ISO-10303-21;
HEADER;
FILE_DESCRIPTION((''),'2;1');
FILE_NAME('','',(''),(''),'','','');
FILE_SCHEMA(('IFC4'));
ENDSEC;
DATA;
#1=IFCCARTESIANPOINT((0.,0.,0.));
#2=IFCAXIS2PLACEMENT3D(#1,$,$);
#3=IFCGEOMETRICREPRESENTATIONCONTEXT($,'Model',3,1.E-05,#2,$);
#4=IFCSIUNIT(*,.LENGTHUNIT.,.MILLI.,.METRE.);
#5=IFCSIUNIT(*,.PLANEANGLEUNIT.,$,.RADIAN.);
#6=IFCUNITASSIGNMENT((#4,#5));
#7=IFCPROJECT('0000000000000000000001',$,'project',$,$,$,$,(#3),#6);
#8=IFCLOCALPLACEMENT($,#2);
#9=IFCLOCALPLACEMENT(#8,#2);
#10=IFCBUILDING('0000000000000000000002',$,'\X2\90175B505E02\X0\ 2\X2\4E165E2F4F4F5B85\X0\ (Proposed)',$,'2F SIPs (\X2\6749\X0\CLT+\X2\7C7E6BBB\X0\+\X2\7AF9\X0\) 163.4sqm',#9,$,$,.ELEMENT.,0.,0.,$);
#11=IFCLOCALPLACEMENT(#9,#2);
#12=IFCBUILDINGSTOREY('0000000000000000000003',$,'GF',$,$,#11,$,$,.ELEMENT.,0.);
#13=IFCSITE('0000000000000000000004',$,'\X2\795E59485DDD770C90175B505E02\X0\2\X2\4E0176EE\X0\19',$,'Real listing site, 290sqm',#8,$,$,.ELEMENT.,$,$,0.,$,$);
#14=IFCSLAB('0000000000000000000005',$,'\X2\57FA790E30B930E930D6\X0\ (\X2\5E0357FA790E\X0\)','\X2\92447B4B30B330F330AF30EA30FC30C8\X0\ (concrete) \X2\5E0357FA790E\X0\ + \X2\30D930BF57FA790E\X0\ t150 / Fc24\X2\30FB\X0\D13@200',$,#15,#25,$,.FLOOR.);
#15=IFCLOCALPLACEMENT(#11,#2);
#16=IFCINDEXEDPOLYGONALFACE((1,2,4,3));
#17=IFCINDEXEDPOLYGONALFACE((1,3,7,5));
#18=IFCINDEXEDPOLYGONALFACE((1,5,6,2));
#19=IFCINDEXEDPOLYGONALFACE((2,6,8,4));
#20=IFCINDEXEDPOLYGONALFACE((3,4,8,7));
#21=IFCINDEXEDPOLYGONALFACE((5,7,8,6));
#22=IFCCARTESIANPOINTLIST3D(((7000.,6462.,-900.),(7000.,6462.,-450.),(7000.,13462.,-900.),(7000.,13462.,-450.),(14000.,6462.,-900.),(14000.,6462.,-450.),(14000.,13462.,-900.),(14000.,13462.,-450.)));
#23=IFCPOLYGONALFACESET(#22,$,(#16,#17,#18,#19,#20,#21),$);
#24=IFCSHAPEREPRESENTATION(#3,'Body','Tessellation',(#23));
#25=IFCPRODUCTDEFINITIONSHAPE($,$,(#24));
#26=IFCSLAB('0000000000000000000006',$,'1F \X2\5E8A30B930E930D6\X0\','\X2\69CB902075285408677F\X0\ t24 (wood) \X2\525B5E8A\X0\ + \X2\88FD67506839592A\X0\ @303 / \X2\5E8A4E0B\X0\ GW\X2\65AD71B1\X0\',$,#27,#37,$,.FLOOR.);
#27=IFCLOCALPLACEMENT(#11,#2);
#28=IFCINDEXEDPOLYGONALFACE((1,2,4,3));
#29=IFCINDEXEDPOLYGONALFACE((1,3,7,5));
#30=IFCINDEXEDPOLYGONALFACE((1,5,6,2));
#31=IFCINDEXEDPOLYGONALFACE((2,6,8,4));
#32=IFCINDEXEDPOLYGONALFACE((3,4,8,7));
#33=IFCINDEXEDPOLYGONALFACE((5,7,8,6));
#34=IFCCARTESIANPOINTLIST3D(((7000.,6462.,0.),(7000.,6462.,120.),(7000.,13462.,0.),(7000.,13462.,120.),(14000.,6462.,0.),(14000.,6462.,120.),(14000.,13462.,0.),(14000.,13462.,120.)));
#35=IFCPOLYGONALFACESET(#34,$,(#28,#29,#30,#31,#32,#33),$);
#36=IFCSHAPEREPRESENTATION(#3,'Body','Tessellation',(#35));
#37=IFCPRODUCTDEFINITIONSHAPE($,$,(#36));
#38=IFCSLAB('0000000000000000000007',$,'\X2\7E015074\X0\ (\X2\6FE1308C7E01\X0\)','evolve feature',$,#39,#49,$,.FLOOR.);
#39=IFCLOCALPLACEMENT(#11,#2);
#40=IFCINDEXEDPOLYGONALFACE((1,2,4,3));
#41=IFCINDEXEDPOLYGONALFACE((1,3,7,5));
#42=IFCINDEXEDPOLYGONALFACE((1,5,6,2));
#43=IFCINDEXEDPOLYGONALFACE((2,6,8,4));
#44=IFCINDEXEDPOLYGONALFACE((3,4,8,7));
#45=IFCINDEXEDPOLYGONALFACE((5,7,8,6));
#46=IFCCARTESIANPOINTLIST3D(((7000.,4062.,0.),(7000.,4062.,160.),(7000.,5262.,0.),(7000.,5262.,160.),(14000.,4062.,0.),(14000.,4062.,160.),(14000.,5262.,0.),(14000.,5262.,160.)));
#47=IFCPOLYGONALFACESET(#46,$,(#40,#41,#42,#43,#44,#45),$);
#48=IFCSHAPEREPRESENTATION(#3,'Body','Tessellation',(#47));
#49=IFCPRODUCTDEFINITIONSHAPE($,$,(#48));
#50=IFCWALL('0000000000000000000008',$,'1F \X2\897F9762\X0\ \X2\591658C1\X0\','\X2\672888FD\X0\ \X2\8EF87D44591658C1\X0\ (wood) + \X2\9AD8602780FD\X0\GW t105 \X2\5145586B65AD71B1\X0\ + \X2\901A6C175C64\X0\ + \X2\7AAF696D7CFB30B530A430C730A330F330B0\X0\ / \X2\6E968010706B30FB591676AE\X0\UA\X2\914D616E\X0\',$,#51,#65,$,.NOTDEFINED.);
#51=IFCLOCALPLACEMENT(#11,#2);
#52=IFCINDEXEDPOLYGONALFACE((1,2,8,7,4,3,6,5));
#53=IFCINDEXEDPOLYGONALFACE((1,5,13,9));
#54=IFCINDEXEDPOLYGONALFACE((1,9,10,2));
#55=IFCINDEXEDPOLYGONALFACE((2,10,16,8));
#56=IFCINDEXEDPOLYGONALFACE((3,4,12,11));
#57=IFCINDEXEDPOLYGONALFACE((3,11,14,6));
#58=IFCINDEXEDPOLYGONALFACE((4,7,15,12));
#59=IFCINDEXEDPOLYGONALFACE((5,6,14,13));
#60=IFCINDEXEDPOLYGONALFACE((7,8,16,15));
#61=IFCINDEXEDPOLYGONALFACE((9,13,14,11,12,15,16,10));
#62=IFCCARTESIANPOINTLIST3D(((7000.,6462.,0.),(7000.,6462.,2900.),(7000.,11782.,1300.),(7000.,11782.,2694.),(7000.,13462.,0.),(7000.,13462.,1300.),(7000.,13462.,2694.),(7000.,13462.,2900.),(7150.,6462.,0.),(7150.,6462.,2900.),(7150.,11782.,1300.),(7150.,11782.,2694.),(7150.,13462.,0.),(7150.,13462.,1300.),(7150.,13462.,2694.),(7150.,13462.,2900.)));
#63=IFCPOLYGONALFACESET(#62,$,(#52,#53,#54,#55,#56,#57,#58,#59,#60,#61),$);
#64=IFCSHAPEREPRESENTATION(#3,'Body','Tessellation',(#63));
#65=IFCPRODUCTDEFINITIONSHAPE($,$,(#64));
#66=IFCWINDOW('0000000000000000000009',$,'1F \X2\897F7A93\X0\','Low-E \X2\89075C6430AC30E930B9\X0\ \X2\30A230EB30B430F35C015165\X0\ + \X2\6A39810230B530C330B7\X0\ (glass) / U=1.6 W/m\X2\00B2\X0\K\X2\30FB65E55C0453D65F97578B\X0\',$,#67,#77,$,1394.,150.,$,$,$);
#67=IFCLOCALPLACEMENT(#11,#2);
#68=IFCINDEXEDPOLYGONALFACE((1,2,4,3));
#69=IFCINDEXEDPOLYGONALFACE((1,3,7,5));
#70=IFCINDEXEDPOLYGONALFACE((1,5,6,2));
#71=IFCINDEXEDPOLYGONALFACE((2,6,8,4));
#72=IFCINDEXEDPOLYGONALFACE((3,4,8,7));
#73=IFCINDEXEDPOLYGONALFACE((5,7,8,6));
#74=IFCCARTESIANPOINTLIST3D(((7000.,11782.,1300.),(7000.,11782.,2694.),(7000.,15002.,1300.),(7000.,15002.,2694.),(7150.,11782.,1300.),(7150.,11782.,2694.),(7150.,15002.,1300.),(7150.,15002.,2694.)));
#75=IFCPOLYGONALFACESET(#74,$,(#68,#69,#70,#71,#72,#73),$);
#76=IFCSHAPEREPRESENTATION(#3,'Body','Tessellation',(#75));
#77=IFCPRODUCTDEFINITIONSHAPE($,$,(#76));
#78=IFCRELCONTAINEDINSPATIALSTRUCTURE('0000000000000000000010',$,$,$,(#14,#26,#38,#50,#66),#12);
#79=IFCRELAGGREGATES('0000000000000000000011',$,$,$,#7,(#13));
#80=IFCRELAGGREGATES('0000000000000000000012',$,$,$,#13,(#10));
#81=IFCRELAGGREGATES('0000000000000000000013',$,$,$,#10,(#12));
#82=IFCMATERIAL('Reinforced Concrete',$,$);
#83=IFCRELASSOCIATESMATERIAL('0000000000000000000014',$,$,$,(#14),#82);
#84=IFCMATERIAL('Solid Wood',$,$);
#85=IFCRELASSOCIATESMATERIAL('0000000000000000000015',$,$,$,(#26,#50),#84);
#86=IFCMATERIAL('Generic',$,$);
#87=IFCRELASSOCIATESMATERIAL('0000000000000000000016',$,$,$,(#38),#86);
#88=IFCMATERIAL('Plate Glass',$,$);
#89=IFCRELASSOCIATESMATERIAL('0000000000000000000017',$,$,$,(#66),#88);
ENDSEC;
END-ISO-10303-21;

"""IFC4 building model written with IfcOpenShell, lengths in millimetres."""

from ifc_helpers import new_model, si_unit, frame, frame_2d, origin, place, context, project, spatial, rectangle, extrude, material, element, fill, save


model = new_model("IFC4")

# Units and contexts
model_context = context("Model", 3, precision=1e-05, world=origin())
ifc_project = project(units=[si_unit("LENGTHUNIT", "METRE", prefix="MILLI"), si_unit("PLANEANGLEUNIT", "RADIAN")], contexts=[model_context])

# Site, building, storey
site_placement = place(None, origin())
site = spatial("IfcSite", under=ifc_project, at=site_placement, Name="神奈川県逗子市2丁目19", ObjectType="Real listing site, 290sqm", CompositionType="ELEMENT", RefElevation=0.0)
building_placement = place(site_placement, origin())
building = spatial("IfcBuilding", under=site, at=building_placement, Name="逗子市 2世帯住宅 (Proposed)", ObjectType="2F SIPs (杉CLT+籾殻+竹) 163.4sqm", CompositionType="ELEMENT", ElevationOfRefHeight=0.0, ElevationOfTerrain=0.0)
storey_placement = place(building_placement, origin())
storey = spatial("IfcBuildingStorey", under=building, at=storey_placement, Name="GF", CompositionType="ELEMENT", Elevation=0.0)

# Slabs
ifc_material_1 = material(Name="Reinforced Concrete")
slab_1_placement = place(storey_placement, frame((3500.0, 3231.0, -450.0)))
element("IfcSlab", 1, at=slab_1_placement, inside=storey, material=ifc_material_1, Name="基礎スラブ (布基礎)", Description="鉄筋コンクリート (concrete) 布基礎 + ベタ基礎 t150 / Fc24・D13@200", PredefinedType="FLOOR", context=model_context, shape_type="SweptSolid", body=[
    extrude(rectangle(XDim=7000.0, YDim=7000.0, at=frame_2d((3500.0, 3500.0))), frame((3500.0, 3231.0, -450.0)), (0.0, 0.0, 1.0), 450.0),
])
ifc_material_2 = material(Name="Solid Wood")
slab_2_placement = place(storey_placement, frame((3500.0, 3231.0, 0.0)))
element("IfcSlab", 2, at=slab_2_placement, inside=storey, material=ifc_material_2, Name="1F 床スラブ", Description="構造用合板 t24 (wood) 剛床 + 製材根太 @303 / 床下 GW断熱", PredefinedType="FLOOR", context=model_context, shape_type="SweptSolid", body=[
    extrude(rectangle(XDim=7000.0, YDim=7000.0, at=frame_2d((3500.0, 3500.0))), frame((3500.0, 3231.0, 0.0)), (0.0, 0.0, 1.0), 120.0),
])
ifc_material_3 = material(Name="Generic")
slab_3_placement = place(storey_placement, frame((3500.0, 2031.0, 0.0)))
element("IfcSlab", 3, at=slab_3_placement, inside=storey, material=ifc_material_3, Name="縁側 (濡れ縁)", Description="evolve feature", PredefinedType="FLOOR", context=model_context, shape_type="SweptSolid", body=[
    extrude(rectangle(XDim=7000.0, YDim=1200.0, at=frame_2d((3500.0, 600.0))), frame((3500.0, 2031.0, 0.0)), (0.0, 0.0, 1.0), 160.0),
])

# Shared definitions
ifc_material_4 = material(Name="Plate Glass")

# Wall, opening, window
wall_1_placement = place(storey_placement, frame((3500.0, 3231.0, 0.0)))
wall_1 = element("IfcWall", 4, at=wall_1_placement, inside=storey, material=ifc_material_2, Name="1F 西面 外壁", Description="木製 軸組外壁 (wood) + 高性能GW t105 充填断熱 + 通気層 + 窯業系サイディング / 準耐火・外皮UA配慮", PredefinedType="NOTDEFINED", context=model_context, shape_type="SweptSolid", body=[
    extrude(rectangle(XDim=150.0, YDim=7000.0, at=frame_2d((75.0, 3500.0))), frame((3500.0, 3231.0, 0.0)), (0.0, 0.0, 1.0), 2900.0),
])
opening_1_placement = place(storey_placement, frame((3500.0, 5891.0, 650.0)))
opening_1 = element("IfcOpeningElement", 5, at=opening_1_placement, cuts=wall_1, PredefinedType="NOTDEFINED", context=model_context, shape_type="SweptSolid", body=[
    extrude(rectangle(XDim=150.0, YDim=3220.0, at=frame_2d((75.0, 1610.0))), frame((3500.0, 5891.0, 650.0)), (0.0, 0.0, 1.0), 1394.0),
])
window_1_placement = place(storey_placement, frame((3500.0, 5891.0, 650.0)))
window_1 = element("IfcWindow", 6, at=window_1_placement, inside=storey, material=ifc_material_4, Name="1F 西窓", Description="Low-E 複層ガラス アルゴン封入 + 樹脂サッシ (glass) / U=1.6 W/m²K・日射取得型", OverallHeight=1394.0, OverallWidth=150.0, context=model_context, shape_type="SweptSolid", body=[
    extrude(rectangle(XDim=150.0, YDim=3220.0, at=frame_2d((75.0, 1610.0))), frame((3500.0, 5891.0, 650.0)), (0.0, 0.0, 1.0), 1394.0),
])
fill(opening_1, window_1)

save(model, "model.ifc")
